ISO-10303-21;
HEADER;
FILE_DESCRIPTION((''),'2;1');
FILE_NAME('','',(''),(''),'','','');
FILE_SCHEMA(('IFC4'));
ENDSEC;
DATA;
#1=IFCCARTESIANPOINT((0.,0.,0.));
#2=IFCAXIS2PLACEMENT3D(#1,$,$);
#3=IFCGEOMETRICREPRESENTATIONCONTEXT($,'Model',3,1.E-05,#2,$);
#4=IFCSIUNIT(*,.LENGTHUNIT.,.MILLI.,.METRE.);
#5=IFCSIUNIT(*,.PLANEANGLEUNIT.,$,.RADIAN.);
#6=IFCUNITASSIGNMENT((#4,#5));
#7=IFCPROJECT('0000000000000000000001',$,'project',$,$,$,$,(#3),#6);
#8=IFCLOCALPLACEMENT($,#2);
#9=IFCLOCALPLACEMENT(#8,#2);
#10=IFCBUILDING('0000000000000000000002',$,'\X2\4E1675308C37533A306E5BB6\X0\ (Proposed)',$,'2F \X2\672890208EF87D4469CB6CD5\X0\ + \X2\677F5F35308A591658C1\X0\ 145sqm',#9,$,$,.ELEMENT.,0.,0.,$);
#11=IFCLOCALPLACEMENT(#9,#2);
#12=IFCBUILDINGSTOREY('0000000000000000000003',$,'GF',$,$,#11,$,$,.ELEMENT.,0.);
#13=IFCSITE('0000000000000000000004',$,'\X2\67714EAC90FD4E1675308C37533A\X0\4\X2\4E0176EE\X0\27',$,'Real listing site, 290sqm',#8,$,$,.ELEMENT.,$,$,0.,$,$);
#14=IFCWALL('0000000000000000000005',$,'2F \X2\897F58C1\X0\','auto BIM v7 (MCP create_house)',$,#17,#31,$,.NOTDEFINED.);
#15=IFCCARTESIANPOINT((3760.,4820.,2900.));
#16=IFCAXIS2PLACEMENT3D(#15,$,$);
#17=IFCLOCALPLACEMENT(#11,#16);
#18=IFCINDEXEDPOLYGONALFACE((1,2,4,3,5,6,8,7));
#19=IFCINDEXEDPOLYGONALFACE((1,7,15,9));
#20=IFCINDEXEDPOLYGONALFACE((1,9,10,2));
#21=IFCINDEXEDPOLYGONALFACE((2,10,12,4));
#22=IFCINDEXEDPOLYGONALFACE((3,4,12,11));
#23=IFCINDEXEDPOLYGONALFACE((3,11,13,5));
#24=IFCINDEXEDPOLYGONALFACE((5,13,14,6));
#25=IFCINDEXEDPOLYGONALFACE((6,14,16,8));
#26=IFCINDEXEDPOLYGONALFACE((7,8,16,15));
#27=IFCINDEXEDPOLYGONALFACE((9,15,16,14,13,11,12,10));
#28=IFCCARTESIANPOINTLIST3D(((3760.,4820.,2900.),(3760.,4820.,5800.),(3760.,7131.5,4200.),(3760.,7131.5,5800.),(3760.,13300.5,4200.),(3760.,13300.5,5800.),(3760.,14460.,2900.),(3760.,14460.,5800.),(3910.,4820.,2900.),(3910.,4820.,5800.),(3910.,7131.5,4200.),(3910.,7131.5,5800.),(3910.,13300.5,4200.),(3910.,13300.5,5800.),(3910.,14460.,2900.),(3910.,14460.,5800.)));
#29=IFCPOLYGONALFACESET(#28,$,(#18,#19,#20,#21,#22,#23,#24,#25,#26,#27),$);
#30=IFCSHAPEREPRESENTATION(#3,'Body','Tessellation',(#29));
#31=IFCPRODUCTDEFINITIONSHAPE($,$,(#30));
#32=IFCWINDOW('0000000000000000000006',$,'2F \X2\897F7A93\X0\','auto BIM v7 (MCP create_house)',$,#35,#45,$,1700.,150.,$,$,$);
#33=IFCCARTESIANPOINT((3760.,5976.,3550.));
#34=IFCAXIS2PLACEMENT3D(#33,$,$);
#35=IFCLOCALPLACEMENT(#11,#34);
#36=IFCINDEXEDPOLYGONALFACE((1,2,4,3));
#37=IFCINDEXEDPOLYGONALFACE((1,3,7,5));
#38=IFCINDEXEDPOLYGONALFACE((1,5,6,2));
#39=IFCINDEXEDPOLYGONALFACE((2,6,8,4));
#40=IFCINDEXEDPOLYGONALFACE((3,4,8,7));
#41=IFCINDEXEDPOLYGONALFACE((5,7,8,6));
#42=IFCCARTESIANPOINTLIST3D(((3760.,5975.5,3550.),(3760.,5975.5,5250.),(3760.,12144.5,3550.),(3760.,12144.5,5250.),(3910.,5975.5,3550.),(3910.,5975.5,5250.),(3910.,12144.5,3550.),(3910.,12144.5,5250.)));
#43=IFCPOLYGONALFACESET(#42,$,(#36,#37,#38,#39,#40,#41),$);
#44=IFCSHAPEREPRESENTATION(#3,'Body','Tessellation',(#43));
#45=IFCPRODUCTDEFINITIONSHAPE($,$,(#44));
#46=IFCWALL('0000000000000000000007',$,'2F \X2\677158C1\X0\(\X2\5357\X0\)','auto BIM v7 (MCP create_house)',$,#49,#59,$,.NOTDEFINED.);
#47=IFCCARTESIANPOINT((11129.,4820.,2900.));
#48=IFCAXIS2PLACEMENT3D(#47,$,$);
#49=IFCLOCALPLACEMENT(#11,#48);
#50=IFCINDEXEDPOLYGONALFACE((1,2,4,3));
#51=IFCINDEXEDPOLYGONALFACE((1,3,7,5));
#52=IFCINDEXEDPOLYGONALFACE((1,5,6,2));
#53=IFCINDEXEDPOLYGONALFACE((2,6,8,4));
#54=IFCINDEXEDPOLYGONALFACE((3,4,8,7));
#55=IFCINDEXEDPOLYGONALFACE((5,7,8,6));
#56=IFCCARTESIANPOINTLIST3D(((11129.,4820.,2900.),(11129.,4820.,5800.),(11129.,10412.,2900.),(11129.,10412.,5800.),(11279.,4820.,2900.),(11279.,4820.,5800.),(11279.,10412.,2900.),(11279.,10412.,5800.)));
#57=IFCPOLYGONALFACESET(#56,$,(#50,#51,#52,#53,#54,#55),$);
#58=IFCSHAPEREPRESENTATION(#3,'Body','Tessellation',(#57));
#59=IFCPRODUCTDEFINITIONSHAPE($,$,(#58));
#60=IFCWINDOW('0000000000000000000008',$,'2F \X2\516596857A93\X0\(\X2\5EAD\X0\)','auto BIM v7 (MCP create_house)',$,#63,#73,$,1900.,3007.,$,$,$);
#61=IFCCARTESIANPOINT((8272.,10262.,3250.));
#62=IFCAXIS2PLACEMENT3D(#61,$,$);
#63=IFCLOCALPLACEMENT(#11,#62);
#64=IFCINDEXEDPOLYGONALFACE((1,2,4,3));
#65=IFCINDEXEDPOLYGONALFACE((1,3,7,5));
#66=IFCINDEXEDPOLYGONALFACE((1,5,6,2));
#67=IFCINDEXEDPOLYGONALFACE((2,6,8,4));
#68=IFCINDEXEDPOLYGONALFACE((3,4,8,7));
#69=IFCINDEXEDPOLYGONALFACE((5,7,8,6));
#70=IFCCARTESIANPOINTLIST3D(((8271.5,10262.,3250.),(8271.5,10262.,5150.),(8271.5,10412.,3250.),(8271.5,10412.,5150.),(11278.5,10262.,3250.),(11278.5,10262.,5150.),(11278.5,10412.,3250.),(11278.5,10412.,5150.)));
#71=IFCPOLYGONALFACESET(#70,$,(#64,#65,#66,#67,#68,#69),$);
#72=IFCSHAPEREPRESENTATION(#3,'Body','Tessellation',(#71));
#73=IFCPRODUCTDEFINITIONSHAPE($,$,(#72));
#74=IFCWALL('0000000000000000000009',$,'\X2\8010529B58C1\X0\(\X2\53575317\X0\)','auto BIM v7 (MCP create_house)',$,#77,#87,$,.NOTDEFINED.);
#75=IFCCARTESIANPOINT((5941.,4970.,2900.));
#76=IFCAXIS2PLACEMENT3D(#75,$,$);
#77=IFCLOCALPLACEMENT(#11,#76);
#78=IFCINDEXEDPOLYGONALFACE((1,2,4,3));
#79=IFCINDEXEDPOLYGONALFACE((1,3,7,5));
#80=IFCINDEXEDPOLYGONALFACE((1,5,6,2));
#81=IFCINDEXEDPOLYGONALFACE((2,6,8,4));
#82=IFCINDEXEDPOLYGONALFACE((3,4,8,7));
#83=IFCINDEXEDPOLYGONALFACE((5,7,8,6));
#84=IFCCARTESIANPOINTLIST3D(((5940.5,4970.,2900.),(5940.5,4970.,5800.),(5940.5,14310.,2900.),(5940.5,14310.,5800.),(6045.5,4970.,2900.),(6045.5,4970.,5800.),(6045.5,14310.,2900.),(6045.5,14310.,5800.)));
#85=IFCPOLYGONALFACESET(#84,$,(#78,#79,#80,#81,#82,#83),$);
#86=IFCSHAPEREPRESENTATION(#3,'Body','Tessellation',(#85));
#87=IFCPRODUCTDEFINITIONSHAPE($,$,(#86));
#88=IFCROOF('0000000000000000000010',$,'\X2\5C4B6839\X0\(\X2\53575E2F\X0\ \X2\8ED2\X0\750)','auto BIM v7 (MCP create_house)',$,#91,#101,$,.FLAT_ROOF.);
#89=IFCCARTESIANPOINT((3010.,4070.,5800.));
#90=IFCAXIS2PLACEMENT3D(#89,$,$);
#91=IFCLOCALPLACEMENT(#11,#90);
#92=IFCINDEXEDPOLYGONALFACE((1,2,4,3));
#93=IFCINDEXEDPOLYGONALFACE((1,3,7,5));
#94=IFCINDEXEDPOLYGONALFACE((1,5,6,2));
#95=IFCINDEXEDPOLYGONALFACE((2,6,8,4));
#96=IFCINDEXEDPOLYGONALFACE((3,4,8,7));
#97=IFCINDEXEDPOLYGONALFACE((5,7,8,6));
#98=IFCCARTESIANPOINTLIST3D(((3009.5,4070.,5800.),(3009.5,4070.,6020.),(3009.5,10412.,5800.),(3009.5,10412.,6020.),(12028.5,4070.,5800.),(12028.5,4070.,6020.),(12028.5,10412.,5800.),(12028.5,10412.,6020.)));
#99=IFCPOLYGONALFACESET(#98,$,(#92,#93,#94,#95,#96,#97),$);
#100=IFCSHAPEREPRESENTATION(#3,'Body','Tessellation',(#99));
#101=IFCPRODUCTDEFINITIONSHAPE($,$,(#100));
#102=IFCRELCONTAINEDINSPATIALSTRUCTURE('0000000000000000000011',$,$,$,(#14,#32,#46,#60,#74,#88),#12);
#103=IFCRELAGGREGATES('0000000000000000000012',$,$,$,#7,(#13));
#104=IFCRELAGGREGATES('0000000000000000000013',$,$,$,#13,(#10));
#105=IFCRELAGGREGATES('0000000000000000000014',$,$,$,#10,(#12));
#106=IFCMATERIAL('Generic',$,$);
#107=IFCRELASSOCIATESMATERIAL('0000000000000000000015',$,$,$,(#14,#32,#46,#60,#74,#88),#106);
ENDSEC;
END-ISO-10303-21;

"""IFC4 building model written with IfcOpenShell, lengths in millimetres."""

from ifc_helpers import new_model, si_unit, frame, frame_2d, origin, place, context, project, spatial, rectangle, extrude, material, element, fill, save


model = new_model("IFC4")

# Units and contexts
model_context = context("Model", 3, precision=1e-05, world=origin())
ifc_project = project(units=[si_unit("LENGTHUNIT", "METRE", prefix="MILLI"), si_unit("PLANEANGLEUNIT", "RADIAN")], contexts=[model_context])

# Site, building, storey
site_placement = place(None, origin())
site = spatial("IfcSite", under=ifc_project, at=site_placement, Name="東京都世田谷区4丁目27", ObjectType="Real listing site, 290sqm", CompositionType="ELEMENT", RefElevation=0.0)
building_placement = place(site_placement, origin())
building = spatial("IfcBuilding", under=site, at=building_placement, Name="世田谷区の家 (Proposed)", ObjectType="2F 木造軸組構法 + 板張り外壁 145sqm", CompositionType="ELEMENT", ElevationOfRefHeight=0.0, ElevationOfTerrain=0.0)
storey_placement = place(building_placement, origin())
storey = spatial("IfcBuildingStorey", under=building, at=storey_placement, Name="GF", CompositionType="ELEMENT", Elevation=0.0)

# Shared definitions
ifc_material = material(Name="Generic")

# Walls, openings, windows
wall_1_placement = place(storey_placement, frame((3760.0, 4820.0, 2900.0)))
wall_1 = element("IfcWall", 1, at=wall_1_placement, inside=storey, material=ifc_material, Name="2F 西壁", Description="auto BIM v7 (MCP create_house)", PredefinedType="NOTDEFINED", context=model_context, shape_type="SweptSolid", body=[
    extrude(rectangle(XDim=150.0, YDim=9640.0, at=frame_2d((75.0, 4820.0))), frame((3760.0, 4820.0, 2900.0)), (0.0, 0.0, 1.0), 2900.0),
])
opening_1_placement = place(storey_placement, frame((3760.0, 5976.0, 3550.0)))
opening_1 = element("IfcOpeningElement", 2, at=opening_1_placement, cuts=wall_1, PredefinedType="NOTDEFINED", context=model_context, shape_type="SweptSolid", body=[
    extrude(rectangle(XDim=150.0, YDim=6169.0, at=frame_2d((75.0, 3084.0))), frame((3760.0, 5976.0, 3550.0)), (0.0, 0.0, 1.0), 1700.0),
])
window_1_placement = place(storey_placement, frame((3760.0, 5976.0, 3550.0)))
window_1 = element("IfcWindow", 3, at=window_1_placement, inside=storey, material=ifc_material, Name="2F 西窓", Description="auto BIM v7 (MCP create_house)", OverallHeight=1700.0, OverallWidth=150.0, context=model_context, shape_type="SweptSolid", body=[
    extrude(rectangle(XDim=150.0, YDim=6169.0, at=frame_2d((75.0, 3084.0))), frame((3760.0, 5976.0, 3550.0)), (0.0, 0.0, 1.0), 1700.0),
])
fill(opening_1, window_1)
wall_2_placement = place(storey_placement, frame((11129.0, 4820.0, 2900.0)))
wall_2 = element("IfcWall", 4, at=wall_2_placement, inside=storey, material=ifc_material, Name="2F 東壁(南)", Description="auto BIM v7 (MCP create_house)", PredefinedType="NOTDEFINED", context=model_context, shape_type="SweptSolid", body=[
    extrude(rectangle(XDim=150.0, YDim=5592.0, at=frame_2d((75.0, 2796.0))), frame((11129.0, 4820.0, 2900.0)), (0.0, 0.0, 1.0), 2900.0),
])
opening_2_placement = place(storey_placement, frame((8272.0, 10262.0, 3250.0)))
opening_2 = element("IfcOpeningElement", 5, at=opening_2_placement, cuts=wall_2, PredefinedType="NOTDEFINED", context=model_context, shape_type="SweptSolid", body=[
    extrude(rectangle(XDim=3007.0, YDim=150.0, at=frame_2d((1503.0, 75.0))), frame((8272.0, 10262.0, 3250.0)), (0.0, 0.0, 1.0), 1900.0),
])
window_2_placement = place(storey_placement, frame((8272.0, 10262.0, 3250.0)))
window_2 = element("IfcWindow", 6, at=window_2_placement, inside=storey, material=ifc_material, Name="2F 入隅窓(庭)", Description="auto BIM v7 (MCP create_house)", OverallHeight=1900.0, OverallWidth=3007.0, context=model_context, shape_type="SweptSolid", body=[
    extrude(rectangle(XDim=3007.0, YDim=150.0, at=frame_2d((1503.0, 75.0))), frame((8272.0, 10262.0, 3250.0)), (0.0, 0.0, 1.0), 1900.0),
])
fill(opening_2, window_2)

# Wall
wall_3_placement = place(storey_placement, frame((5941.0, 4970.0, 2900.0)))
element("IfcWall", 7, at=wall_3_placement, inside=storey, material=ifc_material, Name="耐力壁(南北)", Description="auto BIM v7 (MCP create_house)", PredefinedType="NOTDEFINED", context=model_context, shape_type="SweptSolid", body=[
    extrude(rectangle(XDim=105.0, YDim=9340.0, at=frame_2d((52.0, 4670.0))), frame((5941.0, 4970.0, 2900.0)), (0.0, 0.0, 1.0), 2900.0),
])

# Roof
for number, where, name in (
    (8, (3010.0, 4070.0, 5800.0), "屋根(南帯 軒750)"),
):
    element("IfcRoof", number, at=place(storey_placement, frame(where)), inside=storey, material=ifc_material, Name=name, Description="auto BIM v7 (MCP create_house)", PredefinedType="FLAT_ROOF", context=model_context, shape_type="SweptSolid", body=[
        extrude(rectangle(XDim=9019.0, YDim=6342.0, at=frame_2d((4509.0, 3171.0))), frame((3010.0, 4070.0, 5800.0)), (0.0, 0.0, 1.0), 220.0),
    ])

save(model, "model.ifc")
